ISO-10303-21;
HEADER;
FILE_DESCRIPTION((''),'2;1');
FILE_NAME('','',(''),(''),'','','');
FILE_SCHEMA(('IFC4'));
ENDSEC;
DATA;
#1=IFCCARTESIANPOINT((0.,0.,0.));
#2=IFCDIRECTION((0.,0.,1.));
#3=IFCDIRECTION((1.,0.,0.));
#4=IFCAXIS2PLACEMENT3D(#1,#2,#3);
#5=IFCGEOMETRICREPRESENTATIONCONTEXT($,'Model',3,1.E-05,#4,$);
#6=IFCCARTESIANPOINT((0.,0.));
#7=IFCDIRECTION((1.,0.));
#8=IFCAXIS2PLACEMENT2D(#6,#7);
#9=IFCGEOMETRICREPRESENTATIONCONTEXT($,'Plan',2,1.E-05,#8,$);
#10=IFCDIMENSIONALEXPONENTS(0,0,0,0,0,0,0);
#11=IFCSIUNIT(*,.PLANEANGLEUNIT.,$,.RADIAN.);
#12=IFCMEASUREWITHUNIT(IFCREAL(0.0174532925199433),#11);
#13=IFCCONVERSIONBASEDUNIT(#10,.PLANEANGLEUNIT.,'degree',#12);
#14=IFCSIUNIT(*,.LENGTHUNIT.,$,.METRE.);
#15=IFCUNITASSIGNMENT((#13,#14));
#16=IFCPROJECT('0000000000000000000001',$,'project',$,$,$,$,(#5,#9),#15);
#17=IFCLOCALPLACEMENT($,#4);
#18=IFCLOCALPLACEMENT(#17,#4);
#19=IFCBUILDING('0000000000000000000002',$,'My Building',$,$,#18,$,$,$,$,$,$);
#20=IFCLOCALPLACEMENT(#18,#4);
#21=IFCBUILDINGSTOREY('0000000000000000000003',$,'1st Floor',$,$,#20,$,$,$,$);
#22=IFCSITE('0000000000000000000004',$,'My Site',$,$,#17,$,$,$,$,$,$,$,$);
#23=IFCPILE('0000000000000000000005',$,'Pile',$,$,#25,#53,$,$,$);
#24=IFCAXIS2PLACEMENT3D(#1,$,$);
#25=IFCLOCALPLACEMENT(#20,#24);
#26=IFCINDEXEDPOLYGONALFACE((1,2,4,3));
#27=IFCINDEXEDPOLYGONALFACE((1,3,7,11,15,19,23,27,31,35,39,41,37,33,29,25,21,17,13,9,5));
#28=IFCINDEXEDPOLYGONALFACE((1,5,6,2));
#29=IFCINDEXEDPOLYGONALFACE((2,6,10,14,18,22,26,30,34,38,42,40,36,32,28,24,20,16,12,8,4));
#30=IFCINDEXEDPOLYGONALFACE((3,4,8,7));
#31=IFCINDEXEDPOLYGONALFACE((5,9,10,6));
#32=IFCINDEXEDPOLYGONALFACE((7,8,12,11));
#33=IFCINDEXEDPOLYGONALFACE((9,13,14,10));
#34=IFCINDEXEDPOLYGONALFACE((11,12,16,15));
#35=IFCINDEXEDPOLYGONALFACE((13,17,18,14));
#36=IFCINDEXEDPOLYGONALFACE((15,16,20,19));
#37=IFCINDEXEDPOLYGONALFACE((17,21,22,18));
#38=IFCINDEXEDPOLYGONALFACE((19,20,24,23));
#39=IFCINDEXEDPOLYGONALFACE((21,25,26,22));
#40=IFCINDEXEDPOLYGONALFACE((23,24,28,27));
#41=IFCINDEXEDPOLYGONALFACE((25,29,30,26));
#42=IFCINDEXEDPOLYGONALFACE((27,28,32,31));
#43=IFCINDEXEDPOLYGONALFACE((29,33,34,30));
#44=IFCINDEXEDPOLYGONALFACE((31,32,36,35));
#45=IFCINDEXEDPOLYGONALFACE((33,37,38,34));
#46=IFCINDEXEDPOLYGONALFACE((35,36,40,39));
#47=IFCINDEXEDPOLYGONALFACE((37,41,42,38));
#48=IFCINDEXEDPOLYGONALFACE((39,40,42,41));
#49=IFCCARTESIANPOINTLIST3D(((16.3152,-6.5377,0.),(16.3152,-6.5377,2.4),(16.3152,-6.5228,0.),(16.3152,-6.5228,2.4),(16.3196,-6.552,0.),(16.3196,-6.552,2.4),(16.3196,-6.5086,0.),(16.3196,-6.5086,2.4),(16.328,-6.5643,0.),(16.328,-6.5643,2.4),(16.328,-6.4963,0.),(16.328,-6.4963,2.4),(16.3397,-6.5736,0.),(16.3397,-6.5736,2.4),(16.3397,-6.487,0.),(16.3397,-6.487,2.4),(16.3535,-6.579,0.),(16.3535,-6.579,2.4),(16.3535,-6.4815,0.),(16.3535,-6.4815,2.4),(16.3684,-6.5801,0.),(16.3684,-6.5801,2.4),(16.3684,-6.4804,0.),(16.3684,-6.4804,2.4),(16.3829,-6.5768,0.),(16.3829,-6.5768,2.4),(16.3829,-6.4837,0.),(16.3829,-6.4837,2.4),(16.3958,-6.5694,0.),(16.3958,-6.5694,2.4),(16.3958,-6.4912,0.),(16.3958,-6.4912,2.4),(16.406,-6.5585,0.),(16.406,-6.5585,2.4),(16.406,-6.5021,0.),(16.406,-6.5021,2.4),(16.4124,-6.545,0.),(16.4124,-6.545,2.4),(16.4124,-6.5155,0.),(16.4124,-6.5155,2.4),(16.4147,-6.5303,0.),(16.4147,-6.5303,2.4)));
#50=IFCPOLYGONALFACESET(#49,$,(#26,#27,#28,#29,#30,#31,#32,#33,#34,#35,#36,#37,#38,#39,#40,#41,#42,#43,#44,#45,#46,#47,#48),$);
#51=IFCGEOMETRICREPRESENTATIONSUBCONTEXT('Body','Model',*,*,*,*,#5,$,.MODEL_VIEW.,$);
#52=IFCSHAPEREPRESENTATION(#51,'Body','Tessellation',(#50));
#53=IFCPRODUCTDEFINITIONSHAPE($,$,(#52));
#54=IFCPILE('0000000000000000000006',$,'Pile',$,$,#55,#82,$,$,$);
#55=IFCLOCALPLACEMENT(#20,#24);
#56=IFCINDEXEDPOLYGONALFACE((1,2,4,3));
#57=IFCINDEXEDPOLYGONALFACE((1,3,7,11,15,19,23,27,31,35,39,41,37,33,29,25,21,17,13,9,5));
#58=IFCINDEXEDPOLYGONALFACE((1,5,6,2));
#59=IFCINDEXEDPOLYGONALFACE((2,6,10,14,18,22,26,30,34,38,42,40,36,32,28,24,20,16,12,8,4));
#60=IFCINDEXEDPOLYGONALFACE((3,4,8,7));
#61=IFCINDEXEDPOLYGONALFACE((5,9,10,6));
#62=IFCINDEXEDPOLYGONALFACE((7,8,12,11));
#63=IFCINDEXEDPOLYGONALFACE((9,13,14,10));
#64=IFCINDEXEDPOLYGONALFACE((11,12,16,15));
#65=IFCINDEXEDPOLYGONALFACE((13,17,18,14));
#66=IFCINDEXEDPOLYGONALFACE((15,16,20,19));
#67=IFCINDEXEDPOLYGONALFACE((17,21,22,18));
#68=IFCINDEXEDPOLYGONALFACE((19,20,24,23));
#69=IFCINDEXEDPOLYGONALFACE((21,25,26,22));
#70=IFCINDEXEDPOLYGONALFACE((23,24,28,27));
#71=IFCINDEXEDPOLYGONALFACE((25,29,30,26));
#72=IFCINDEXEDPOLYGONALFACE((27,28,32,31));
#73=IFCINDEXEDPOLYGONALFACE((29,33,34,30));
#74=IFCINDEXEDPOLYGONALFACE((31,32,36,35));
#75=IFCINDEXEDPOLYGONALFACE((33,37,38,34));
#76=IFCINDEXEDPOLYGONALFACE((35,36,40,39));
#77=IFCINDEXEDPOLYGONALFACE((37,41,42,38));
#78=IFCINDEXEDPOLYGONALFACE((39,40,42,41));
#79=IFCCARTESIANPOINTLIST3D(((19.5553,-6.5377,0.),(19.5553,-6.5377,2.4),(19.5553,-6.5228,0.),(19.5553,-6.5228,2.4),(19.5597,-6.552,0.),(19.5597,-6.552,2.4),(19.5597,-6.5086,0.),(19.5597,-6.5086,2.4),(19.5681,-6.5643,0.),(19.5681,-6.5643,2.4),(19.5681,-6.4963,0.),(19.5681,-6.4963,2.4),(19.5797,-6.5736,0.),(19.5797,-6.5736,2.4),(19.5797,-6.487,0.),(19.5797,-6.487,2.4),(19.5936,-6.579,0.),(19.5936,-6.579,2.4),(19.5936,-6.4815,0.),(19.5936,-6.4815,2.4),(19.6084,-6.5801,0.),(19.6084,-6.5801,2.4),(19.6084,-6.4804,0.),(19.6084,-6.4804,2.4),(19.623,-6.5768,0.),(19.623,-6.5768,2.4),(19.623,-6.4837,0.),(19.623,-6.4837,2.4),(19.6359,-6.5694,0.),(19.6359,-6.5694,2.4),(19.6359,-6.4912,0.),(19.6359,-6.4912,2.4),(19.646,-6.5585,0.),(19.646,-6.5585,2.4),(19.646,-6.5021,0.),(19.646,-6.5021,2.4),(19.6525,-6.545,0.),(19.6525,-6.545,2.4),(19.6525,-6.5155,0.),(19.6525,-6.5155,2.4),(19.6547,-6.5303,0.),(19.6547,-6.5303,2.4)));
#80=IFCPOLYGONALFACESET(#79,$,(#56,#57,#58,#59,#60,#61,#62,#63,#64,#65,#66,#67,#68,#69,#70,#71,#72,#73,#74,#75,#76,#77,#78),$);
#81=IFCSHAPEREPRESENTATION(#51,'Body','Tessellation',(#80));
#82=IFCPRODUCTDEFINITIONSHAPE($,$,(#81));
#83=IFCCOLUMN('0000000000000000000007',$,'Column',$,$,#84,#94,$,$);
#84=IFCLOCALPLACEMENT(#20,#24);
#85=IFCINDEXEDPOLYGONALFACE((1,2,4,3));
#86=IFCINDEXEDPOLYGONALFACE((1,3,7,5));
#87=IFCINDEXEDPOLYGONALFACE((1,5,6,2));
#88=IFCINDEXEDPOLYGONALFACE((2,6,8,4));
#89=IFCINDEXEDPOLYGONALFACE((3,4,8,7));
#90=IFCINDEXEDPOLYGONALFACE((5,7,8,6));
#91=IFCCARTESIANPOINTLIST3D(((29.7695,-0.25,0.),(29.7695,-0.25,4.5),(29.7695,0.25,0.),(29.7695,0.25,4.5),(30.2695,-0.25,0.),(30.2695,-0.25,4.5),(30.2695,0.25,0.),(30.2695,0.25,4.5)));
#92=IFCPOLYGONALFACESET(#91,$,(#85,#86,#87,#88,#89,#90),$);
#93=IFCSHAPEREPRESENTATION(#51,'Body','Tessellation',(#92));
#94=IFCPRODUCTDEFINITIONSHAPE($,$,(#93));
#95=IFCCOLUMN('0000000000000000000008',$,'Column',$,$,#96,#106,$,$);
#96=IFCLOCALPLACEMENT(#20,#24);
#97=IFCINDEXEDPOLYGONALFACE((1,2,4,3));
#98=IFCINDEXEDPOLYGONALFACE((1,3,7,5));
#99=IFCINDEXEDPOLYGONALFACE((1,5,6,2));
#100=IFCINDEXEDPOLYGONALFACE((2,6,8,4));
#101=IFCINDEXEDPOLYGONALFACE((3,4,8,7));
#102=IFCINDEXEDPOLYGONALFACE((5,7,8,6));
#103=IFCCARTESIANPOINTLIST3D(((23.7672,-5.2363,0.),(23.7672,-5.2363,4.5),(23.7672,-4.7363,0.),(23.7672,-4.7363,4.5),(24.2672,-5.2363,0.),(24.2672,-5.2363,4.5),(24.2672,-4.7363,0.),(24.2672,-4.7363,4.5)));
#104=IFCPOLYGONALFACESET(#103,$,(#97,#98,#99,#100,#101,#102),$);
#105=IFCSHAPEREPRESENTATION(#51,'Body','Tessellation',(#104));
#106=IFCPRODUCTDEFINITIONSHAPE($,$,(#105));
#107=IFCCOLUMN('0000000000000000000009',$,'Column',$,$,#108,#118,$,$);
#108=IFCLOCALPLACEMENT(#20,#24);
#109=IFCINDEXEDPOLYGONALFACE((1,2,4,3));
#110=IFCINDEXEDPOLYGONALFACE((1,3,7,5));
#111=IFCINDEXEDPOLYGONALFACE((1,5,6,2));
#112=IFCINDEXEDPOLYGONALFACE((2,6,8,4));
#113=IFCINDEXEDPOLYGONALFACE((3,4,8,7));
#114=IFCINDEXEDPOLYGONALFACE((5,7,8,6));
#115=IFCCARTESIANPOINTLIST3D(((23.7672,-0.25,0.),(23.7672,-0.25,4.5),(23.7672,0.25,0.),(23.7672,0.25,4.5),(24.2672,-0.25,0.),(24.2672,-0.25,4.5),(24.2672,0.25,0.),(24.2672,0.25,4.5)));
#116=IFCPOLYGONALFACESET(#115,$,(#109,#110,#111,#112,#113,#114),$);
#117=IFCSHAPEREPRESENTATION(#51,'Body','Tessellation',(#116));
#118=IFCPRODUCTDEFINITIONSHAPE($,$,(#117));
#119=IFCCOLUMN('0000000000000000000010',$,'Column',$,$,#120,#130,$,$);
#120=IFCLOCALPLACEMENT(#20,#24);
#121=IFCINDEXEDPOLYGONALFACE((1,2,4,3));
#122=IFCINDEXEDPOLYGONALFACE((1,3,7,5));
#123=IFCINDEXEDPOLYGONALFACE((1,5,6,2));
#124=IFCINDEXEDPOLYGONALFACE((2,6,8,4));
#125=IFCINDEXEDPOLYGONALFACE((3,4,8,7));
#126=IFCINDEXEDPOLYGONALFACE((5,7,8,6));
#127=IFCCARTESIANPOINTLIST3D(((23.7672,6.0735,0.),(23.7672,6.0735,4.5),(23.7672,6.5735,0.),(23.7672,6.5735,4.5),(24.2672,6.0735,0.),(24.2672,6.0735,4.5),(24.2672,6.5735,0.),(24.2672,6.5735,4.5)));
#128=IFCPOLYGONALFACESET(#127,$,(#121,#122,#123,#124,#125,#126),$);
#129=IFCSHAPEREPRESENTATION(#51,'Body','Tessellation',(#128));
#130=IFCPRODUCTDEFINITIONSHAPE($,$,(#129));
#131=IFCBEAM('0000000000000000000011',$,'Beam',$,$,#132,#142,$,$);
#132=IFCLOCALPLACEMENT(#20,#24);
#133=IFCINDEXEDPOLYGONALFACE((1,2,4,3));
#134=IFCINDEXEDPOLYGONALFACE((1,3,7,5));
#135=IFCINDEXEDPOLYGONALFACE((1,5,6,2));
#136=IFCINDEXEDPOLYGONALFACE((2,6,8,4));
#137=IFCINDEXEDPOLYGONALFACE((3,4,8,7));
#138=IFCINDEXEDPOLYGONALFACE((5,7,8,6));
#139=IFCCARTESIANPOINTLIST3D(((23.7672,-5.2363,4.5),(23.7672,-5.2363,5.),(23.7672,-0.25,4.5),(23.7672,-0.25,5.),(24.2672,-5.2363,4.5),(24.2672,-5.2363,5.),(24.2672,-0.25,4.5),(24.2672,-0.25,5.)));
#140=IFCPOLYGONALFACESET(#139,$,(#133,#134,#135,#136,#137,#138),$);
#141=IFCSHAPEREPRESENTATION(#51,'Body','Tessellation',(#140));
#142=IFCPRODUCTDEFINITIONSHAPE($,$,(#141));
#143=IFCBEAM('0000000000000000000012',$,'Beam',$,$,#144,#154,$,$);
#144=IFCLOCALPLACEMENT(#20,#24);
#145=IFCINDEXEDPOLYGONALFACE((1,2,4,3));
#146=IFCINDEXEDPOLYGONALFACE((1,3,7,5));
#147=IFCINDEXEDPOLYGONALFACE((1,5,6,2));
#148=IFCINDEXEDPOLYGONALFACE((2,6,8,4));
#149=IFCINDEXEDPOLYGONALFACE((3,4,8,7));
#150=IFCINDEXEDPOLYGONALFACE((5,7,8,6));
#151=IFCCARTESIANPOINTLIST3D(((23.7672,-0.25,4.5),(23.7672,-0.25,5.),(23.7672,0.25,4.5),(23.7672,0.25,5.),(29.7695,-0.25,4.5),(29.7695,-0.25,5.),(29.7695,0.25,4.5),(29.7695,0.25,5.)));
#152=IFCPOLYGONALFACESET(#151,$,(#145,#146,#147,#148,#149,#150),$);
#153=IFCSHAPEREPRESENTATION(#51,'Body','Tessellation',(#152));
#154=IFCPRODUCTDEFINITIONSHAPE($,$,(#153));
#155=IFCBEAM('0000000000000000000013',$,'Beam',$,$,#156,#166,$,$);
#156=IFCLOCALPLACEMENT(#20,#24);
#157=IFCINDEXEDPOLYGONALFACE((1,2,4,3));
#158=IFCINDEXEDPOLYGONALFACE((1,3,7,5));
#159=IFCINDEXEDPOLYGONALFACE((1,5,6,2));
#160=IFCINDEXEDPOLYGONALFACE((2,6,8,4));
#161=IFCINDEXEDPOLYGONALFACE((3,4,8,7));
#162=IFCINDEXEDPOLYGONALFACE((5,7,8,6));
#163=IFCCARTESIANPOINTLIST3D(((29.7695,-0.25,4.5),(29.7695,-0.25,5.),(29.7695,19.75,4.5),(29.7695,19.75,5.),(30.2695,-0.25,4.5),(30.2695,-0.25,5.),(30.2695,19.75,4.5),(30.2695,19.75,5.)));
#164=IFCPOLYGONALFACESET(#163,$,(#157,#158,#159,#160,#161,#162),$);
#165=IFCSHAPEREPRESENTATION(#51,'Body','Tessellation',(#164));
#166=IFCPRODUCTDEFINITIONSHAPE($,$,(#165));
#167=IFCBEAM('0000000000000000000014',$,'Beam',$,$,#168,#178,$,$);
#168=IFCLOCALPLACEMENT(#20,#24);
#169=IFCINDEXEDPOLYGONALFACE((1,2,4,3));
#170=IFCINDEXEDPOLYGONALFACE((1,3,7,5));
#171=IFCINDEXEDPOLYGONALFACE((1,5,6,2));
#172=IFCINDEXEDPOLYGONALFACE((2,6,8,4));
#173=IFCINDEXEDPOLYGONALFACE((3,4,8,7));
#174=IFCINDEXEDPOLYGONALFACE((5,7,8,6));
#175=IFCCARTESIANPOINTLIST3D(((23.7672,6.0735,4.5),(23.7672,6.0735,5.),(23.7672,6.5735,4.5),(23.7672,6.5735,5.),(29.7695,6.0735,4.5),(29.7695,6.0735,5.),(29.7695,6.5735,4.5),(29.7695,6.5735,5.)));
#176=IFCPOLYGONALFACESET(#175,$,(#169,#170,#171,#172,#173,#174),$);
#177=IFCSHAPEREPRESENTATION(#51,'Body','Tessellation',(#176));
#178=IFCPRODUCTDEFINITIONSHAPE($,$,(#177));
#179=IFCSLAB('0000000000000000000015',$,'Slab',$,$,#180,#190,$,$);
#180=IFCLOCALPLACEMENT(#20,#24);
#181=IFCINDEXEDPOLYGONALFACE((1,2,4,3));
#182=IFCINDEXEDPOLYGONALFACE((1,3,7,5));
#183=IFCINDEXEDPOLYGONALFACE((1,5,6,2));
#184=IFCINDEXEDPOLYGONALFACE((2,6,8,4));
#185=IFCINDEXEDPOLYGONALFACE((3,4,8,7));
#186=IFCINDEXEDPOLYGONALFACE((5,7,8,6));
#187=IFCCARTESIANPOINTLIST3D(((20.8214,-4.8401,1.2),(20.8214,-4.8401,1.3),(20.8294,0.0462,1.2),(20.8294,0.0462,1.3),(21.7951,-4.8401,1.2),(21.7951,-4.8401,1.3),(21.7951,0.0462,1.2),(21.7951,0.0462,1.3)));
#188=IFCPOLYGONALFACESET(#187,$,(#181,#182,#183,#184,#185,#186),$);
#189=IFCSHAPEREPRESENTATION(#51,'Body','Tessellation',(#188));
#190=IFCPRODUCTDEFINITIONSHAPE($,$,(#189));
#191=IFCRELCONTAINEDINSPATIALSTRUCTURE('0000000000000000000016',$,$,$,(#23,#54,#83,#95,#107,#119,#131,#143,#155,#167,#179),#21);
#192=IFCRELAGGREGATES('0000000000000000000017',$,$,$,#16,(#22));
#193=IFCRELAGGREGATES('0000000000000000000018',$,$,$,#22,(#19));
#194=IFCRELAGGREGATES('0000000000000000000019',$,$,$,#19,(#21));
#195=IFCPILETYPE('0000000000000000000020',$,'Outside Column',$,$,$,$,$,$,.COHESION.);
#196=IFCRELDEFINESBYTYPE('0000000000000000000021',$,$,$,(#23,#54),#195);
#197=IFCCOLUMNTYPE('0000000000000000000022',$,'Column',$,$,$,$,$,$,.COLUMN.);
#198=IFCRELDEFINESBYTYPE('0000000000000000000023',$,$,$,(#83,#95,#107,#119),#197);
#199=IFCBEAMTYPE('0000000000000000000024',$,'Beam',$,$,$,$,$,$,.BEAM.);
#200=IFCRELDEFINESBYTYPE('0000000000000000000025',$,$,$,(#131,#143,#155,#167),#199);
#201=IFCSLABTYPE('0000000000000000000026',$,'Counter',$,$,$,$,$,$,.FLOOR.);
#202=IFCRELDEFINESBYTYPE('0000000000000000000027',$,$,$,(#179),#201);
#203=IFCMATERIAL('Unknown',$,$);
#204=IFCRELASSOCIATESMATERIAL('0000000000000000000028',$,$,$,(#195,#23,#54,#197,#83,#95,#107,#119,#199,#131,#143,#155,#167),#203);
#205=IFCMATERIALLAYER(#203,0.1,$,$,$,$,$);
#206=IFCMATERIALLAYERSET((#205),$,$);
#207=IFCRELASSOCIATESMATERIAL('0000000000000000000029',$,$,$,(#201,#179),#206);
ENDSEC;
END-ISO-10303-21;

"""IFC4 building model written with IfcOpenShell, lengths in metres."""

from ifc_helpers import new_model, entity, si_unit, converted_unit, frame, origin_with_axes, origin_2d_with_axis, place, context, subcontext, project, spatial, indexed_curve, rectangle, circle, outline, extrude, material, layer, layer_set, layer_usage, material_profile, profile_set, profile_usage, type_object, element, save


model = new_model("IFC4")

# Units and contexts
model_context = context("Model", 3, precision=1e-05, world=origin_with_axes())
plan_context = context("Plan", 2, precision=1e-05, world=origin_2d_with_axis())
body_context_1 = subcontext(model_context, "Body", "Model", "MODEL_VIEW")
ifc_project = project(units=[converted_unit("PLANEANGLEUNIT", "degree", entity("IfcReal", 0.0174532925199433), si_unit("PLANEANGLEUNIT", "RADIAN"), dimensions=[0, 0, 0, 0, 0, 0, 0]), si_unit("LENGTHUNIT", "METRE")], contexts=[model_context, plan_context])

# Site, building, storey
site_placement = place(None, origin_with_axes())
site = spatial("IfcSite", under=ifc_project, at=site_placement, Name="My Site")
building_placement = place(site_placement, origin_with_axes())
building = spatial("IfcBuilding", under=site, at=building_placement, Name="My Building")
storey_placement = place(building_placement, origin_with_axes())
storey = spatial("IfcBuildingStorey", under=building, at=storey_placement, Name="1st Floor")

# Piles
ifc_material = material(Name="Unknown")
ifc_material_profile_1 = material_profile(ifc_material, circle(Radius=0.05))
ifc_profile_set_1 = profile_set([ifc_material_profile_1])
ifc_profile_usage_1 = profile_usage(ifc_profile_set_1, cardinal=5)
pile_type = type_object("IfcPileType", Name="Outside Column", PredefinedType="COHESION", material=ifc_profile_set_1)
pile_1_placement = place(storey_placement, frame((16.3647, -6.5303, 0.0), z_axis=(0.0, 0.0, 1.0), x_axis=(1.0, 0.0, 0.0)))
element("IfcPile", 1, at=pile_1_placement, inside=storey, type_object=pile_type, material=ifc_profile_usage_1, Name="Pile", context=body_context_1, shape_type="SweptSolid", body=[
    extrude(circle(Radius=0.05), origin_with_axes(), (0.0, 0.0, 1.0), 2.4),
])
ifc_profile_usage_2 = profile_usage(ifc_profile_set_1, cardinal=5)
pile_2_placement = place(storey_placement, frame((19.6047, -6.5303, 0.0), z_axis=(0.0, 0.0, 1.0), x_axis=(1.0, 0.0, 0.0)))
element("IfcPile", 2, at=pile_2_placement, inside=storey, type_object=pile_type, material=ifc_profile_usage_2, Name="Pile", context=body_context_1, shape_type="SweptSolid", body=[
    extrude(circle(Radius=0.05), origin_with_axes(), (0.0, 0.0, 1.0), 2.4),
])

# Columns
ifc_material_profile_2 = material_profile(ifc_material, rectangle(XDim=0.5, YDim=0.5))
ifc_profile_set_2 = profile_set([ifc_material_profile_2])
ifc_profile_usage_3 = profile_usage(ifc_profile_set_2, cardinal=5)
column_type = type_object("IfcColumnType", Name="Column", PredefinedType="COLUMN", material=ifc_profile_set_2)
column_1_placement = place(storey_placement, frame((30.0195, 0.0, 0.0), z_axis=(0.0, 0.0, 1.0), x_axis=(1.0, 0.0, 0.0)))
element("IfcColumn", 3, at=column_1_placement, inside=storey, type_object=column_type, material=ifc_profile_usage_3, Name="Column", context=body_context_1, shape_type="SweptSolid", body=[
    extrude(rectangle(XDim=0.5, YDim=0.5), origin_with_axes(), (0.0, 0.0, 1.0), 4.5),
])
ifc_profile_usage_4 = profile_usage(ifc_profile_set_2, cardinal=5)
column_2_placement = place(storey_placement, frame((24.0172, -4.9863, 0.0), z_axis=(0.0, 0.0, 1.0), x_axis=(1.0, 0.0, 0.0)))
element("IfcColumn", 4, at=column_2_placement, inside=storey, type_object=column_type, material=ifc_profile_usage_4, Name="Column", context=body_context_1, shape_type="SweptSolid", body=[
    extrude(rectangle(XDim=0.5, YDim=0.5), origin_with_axes(), (0.0, 0.0, 1.0), 4.5),
])
ifc_profile_usage_5 = profile_usage(ifc_profile_set_2, cardinal=5)
column_3_placement = place(storey_placement, frame((24.0172, 0.0, 0.0), z_axis=(0.0, 0.0, 1.0), x_axis=(1.0, 0.0, 0.0)))
element("IfcColumn", 5, at=column_3_placement, inside=storey, type_object=column_type, material=ifc_profile_usage_5, Name="Column", context=body_context_1, shape_type="SweptSolid", body=[
    extrude(rectangle(XDim=0.5, YDim=0.5), origin_with_axes(), (0.0, 0.0, 1.0), 4.5),
])
ifc_profile_usage_6 = profile_usage(ifc_profile_set_2, cardinal=5)
column_4_placement = place(storey_placement, frame((24.0172, 6.3235, 0.0), z_axis=(0.0, 0.0, 1.0), x_axis=(1.0, 0.0, 0.0)))
element("IfcColumn", 6, at=column_4_placement, inside=storey, type_object=column_type, material=ifc_profile_usage_6, Name="Column", context=body_context_1, shape_type="SweptSolid", body=[
    extrude(rectangle(XDim=0.5, YDim=0.5), origin_with_axes(), (0.0, 0.0, 1.0), 4.5),
])

# Beams
ifc_material_profile_3 = material_profile(ifc_material, rectangle(XDim=0.5, YDim=0.5))
ifc_profile_set_3 = profile_set([ifc_material_profile_3])
ifc_profile_usage_7 = profile_usage(ifc_profile_set_3, cardinal=2)
beam_type = type_object("IfcBeamType", Name="Beam", PredefinedType="BEAM", material=ifc_profile_set_3)
beam_1_placement = place(storey_placement, frame((24.0172, -5.2363, 4.5), z_axis=(0.0, 1.0, 0.0), x_axis=(-1.0, 0.0, 0.0)))
element("IfcBeam", 7, at=beam_1_placement, inside=storey, type_object=beam_type, material=ifc_profile_usage_7, Name="Beam", context=body_context_1, shape_type="SweptSolid", body=[
    extrude(rectangle(XDim=0.5, YDim=0.5), frame((0.0, 0.25, 0.0), z_axis=(0.0, 0.0, 1.0), x_axis=(1.0, 0.0, 0.0)), (0.0, 0.0, 1.0), 4.9863),
])
ifc_profile_usage_8 = profile_usage(ifc_profile_set_3, cardinal=2)
beam_2_placement = place(storey_placement, frame((23.7672, 0.0, 4.5), z_axis=(1.0, 0.0, 0.0), x_axis=(0.0, 1.0, 0.0)))
element("IfcBeam", 8, at=beam_2_placement, inside=storey, type_object=beam_type, material=ifc_profile_usage_8, Name="Beam", context=body_context_1, shape_type="SweptSolid", body=[
    extrude(rectangle(XDim=0.5, YDim=0.5), frame((0.0, 0.25, 0.0), z_axis=(0.0, 0.0, 1.0), x_axis=(1.0, 0.0, 0.0)), (0.0, 0.0, 1.0), 6.0023),
])
ifc_profile_usage_9 = profile_usage(ifc_profile_set_3, cardinal=2)
beam_3_placement = place(storey_placement, frame((30.0195, -0.25, 4.5), z_axis=(0.0, 1.0, 0.0), x_axis=(-1.0, 0.0, 0.0)))
element("IfcBeam", 9, at=beam_3_placement, inside=storey, type_object=beam_type, material=ifc_profile_usage_9, Name="Beam", context=body_context_1, shape_type="SweptSolid", body=[
    extrude(rectangle(XDim=0.5, YDim=0.5), frame((0.0, 0.25, 0.0), z_axis=(0.0, 0.0, 1.0), x_axis=(1.0, 0.0, 0.0)), (0.0, 0.0, 1.0), 20.0),
])
ifc_profile_usage_10 = profile_usage(ifc_profile_set_3, cardinal=2)
beam_4_placement = place(storey_placement, frame((23.7672, 6.3235, 4.5), z_axis=(1.0, 0.0, 0.0), x_axis=(0.0, 1.0, 0.0)))
element("IfcBeam", 10, at=beam_4_placement, inside=storey, type_object=beam_type, material=ifc_profile_usage_10, Name="Beam", context=body_context_1, shape_type="SweptSolid", body=[
    extrude(rectangle(XDim=0.5, YDim=0.5), frame((0.0, 0.25, 0.0), z_axis=(0.0, 0.0, 1.0), x_axis=(1.0, 0.0, 0.0)), (0.0, 0.0, 1.0), 6.0023),
])

# Slab
ifc_layer_1 = layer(ifc_material, 0.1)
ifc_layer_set_1 = layer_set([ifc_layer_1])
ifc_layer_usage_1 = layer_usage(ifc_layer_set_1, "AXIS3", "POSITIVE", -0.1)
slab_type_1 = type_object("IfcSlabType", Name="Counter", PredefinedType="FLOOR", material=ifc_layer_set_1)
slab_1_placement = place(storey_placement, frame((20.8294, 0.0462, 1.3), z_axis=(0.0, 0.0, 1.0), x_axis=(1.0, 0.0, 0.0)))
element("IfcSlab", 11, at=slab_1_placement, inside=storey, type_object=slab_type_1, material=ifc_layer_usage_1, Name="Slab", context=body_context_1, shape_type="SweptSolid", body=[
    extrude(outline(indexed_curve([(0.0, 0.0), (-0.008, -4.8863), (0.9656, -4.8863), (0.9656, 0.0), (0.0, 0.0)])), frame((0.0, 0.0, -0.1), z_axis=(0.0, 0.0, 1.0), x_axis=(1.0, 0.0, 0.0)), (0.0, 0.0, 1.0), 0.1),
])

save(model, "model.ifc")
